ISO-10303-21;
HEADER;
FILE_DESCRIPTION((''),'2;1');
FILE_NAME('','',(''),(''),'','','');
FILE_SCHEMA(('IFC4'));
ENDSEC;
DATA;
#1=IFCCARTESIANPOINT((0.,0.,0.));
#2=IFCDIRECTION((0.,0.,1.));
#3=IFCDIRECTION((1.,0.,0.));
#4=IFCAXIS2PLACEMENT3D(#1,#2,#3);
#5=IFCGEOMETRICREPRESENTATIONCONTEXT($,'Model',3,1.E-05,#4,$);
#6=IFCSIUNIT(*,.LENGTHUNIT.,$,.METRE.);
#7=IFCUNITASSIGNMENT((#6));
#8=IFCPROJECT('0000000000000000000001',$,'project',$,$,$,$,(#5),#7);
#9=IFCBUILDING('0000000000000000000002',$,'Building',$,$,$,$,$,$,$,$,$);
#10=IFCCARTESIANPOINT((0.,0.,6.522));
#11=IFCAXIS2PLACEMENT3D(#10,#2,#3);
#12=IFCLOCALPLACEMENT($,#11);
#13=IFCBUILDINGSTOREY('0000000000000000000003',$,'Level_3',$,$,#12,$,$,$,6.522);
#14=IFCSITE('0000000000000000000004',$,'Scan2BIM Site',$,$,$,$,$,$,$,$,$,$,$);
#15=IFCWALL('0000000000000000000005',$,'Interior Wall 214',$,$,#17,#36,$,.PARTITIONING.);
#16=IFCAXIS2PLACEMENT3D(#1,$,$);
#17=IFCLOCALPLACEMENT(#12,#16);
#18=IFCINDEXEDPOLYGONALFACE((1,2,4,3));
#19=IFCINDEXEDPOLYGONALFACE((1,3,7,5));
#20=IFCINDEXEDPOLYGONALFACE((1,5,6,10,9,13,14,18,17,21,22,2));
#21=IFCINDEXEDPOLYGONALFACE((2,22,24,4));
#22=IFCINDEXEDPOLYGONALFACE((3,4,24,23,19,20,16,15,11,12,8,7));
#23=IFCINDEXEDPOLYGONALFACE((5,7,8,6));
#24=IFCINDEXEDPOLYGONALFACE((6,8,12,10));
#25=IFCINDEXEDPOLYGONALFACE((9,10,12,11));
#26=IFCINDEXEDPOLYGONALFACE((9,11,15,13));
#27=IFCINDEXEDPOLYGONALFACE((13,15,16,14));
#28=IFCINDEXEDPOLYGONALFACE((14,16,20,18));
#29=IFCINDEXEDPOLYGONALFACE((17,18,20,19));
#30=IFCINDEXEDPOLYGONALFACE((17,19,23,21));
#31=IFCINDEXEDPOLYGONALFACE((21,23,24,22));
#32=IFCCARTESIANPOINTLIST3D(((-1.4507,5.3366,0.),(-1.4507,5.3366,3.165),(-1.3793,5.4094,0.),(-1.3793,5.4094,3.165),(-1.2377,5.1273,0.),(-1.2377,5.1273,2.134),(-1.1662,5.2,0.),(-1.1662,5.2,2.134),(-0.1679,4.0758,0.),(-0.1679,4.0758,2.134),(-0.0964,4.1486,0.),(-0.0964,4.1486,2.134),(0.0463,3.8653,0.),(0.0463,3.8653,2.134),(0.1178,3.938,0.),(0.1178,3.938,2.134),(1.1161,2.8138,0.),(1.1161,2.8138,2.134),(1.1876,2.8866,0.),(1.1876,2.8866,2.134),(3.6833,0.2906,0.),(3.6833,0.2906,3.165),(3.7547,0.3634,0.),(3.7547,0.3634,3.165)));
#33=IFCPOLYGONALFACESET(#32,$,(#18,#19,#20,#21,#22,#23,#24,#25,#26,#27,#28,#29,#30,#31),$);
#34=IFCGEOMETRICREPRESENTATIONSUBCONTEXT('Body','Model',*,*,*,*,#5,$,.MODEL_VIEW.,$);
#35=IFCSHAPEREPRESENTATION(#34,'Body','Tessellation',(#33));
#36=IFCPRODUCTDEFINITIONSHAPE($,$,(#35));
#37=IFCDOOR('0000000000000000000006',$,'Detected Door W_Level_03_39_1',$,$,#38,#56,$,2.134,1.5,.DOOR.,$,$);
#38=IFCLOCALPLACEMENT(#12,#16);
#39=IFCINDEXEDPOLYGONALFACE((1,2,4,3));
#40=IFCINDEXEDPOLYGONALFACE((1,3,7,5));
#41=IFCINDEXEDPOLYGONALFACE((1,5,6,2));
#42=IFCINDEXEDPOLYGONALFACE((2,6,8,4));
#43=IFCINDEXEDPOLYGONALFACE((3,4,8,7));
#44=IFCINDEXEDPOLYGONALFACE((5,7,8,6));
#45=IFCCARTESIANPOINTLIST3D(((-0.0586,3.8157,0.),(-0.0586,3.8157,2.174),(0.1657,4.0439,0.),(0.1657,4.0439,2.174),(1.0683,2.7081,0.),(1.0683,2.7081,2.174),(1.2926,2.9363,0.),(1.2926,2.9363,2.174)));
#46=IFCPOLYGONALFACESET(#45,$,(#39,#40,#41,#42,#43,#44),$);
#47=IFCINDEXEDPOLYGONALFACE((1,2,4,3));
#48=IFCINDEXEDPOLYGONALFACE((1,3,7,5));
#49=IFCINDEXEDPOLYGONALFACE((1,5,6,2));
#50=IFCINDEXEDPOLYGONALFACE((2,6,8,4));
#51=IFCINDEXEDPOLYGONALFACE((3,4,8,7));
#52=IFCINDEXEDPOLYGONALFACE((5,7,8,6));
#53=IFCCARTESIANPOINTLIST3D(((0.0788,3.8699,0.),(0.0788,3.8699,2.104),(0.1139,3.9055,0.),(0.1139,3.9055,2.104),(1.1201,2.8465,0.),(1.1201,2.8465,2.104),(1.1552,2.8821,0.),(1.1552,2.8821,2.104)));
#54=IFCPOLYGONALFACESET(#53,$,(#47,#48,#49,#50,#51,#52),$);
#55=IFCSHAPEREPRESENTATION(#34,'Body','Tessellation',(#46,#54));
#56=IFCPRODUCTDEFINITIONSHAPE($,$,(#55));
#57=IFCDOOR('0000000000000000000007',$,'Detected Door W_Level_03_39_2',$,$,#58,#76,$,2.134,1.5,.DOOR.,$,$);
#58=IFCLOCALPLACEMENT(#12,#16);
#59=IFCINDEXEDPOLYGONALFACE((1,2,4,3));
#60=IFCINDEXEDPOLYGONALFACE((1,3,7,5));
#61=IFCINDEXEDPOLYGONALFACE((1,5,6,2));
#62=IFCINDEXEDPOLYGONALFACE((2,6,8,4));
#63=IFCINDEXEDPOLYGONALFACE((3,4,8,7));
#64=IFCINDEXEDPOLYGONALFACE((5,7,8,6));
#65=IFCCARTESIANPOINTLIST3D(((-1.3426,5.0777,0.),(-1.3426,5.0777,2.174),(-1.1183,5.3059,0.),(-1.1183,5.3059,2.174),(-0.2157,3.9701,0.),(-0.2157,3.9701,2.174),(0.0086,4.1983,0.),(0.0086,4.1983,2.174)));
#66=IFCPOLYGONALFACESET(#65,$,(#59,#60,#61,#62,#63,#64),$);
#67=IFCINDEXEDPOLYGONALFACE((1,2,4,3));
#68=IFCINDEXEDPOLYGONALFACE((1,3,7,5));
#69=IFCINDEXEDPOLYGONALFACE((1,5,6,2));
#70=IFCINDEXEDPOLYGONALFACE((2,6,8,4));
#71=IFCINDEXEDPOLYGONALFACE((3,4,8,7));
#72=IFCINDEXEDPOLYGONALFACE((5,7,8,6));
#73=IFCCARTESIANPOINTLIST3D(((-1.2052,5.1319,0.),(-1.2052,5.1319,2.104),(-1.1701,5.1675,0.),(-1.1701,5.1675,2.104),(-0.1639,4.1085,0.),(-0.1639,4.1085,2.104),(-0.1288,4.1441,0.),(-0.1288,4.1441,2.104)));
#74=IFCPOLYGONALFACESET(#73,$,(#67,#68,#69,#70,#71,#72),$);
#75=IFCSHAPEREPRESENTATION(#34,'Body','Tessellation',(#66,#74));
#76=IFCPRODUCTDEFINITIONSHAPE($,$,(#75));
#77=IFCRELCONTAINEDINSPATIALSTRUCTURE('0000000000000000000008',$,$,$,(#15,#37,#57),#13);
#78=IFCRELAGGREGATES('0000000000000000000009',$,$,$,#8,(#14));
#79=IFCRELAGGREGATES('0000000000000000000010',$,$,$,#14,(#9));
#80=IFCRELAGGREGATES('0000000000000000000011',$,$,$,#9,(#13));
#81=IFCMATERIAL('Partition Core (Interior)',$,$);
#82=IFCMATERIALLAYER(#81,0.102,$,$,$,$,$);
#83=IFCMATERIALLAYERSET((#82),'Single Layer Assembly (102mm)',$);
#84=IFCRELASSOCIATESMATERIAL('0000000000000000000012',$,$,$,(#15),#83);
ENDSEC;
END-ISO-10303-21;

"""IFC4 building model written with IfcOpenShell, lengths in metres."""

from ifc_helpers import new_model, si_unit, frame, origin, origin_with_axes, place, context, subcontext, project, spatial, rectangle, extrude, material, layer, layer_set, element, fill, save


model = new_model("IFC4")

# Units and contexts
model_context = context("Model", 3, precision=1e-05, world=origin_with_axes())
body_context = subcontext(model_context, "Body", "Model", "MODEL_VIEW")
ifc_project = project(units=[si_unit("LENGTHUNIT", "METRE")], contexts=[model_context])

# Site, building, storey
site = spatial("IfcSite", under=ifc_project, Name="Scan2BIM Site")
building = spatial("IfcBuilding", under=site, Name="Building")
storey_placement = place(None, frame((0.0, 0.0, 6.522), z_axis=(0.0, 0.0, 1.0), x_axis=(1.0, 0.0, 0.0)))
storey = spatial("IfcBuildingStorey", under=building, at=storey_placement, Name="Level_3", Elevation=6.522)

# Wall, openings, doors
ifc_material_1 = material(Name="Partition Core (Interior)")
ifc_layer_1 = layer(ifc_material_1, 0.102)
ifc_layer_set_1 = layer_set([ifc_layer_1], Name="Single Layer Assembly (102mm)")
wall_1_placement = place(storey_placement, frame((1.152, 2.85, 0.0), z_axis=(0.0, 0.0, 1.0), x_axis=(-0.713193, 0.700968, 0.0)))
wall_1 = element("IfcWall", 1, at=wall_1_placement, inside=storey, material=ifc_layer_set_1, Name="Interior Wall 214", PredefinedType="PARTITIONING", context=body_context, shape_type="SweptSolid", body=[
    extrude(rectangle(XDim=7.1986, YDim=0.102), origin(), (0.0, 0.0, 1.0), 3.165),
])
opening_1_placement = place(None, frame((0.617, 3.376, 6.522), z_axis=(0.0, 0.0, 1.0), x_axis=(-0.713193, 0.700968, 0.0)))
opening_1 = element("IfcOpeningElement", 2, at=opening_1_placement, cuts=wall_1, PredefinedType="OPENING", context=body_context, shape_type="SweptSolid", body=[
    extrude(rectangle(XDim=1.5, YDim=0.202), origin(), (0.0, 0.0, 1.0), 2.134),
])
opening_2_placement = place(None, frame((-0.667, 4.638, 6.522), z_axis=(0.0, 0.0, 1.0), x_axis=(-0.713193, 0.700968, 0.0)))
opening_2 = element("IfcOpeningElement", 3, at=opening_2_placement, cuts=wall_1, PredefinedType="OPENING", context=body_context, shape_type="SweptSolid", body=[
    extrude(rectangle(XDim=1.5, YDim=0.202), origin(), (0.0, 0.0, 1.0), 2.134),
])
door_1_placement = place(opening_1_placement, frame((0.0, 0.0, 0.0), z_axis=(0.0, 0.0, 1.0), x_axis=(1.0, 0.0, 0.0)))
door_1 = element("IfcDoor", 4, at=door_1_placement, inside=storey, Name="Detected Door W_Level_03_39_1", OverallHeight=2.134, OverallWidth=1.5, PredefinedType="DOOR", context=body_context, shape_type="SweptSolid", body=[
    extrude(rectangle(XDim=1.58, YDim=0.32), origin(), (0.0, 0.0, 1.0), 2.174),
    extrude(rectangle(XDim=1.46, YDim=0.05), origin(), (0.0, 0.0, 1.0), 2.104),
])
fill(opening_1, door_1)
door_2_placement = place(opening_2_placement, frame((0.0, 0.0, 0.0), z_axis=(0.0, 0.0, 1.0), x_axis=(1.0, 0.0, 0.0)))
door_2 = element("IfcDoor", 5, at=door_2_placement, inside=storey, Name="Detected Door W_Level_03_39_2", OverallHeight=2.134, OverallWidth=1.5, PredefinedType="DOOR", context=body_context, shape_type="SweptSolid", body=[
    extrude(rectangle(XDim=1.58, YDim=0.32), origin(), (0.0, 0.0, 1.0), 2.174),
    extrude(rectangle(XDim=1.46, YDim=0.05), origin(), (0.0, 0.0, 1.0), 2.104),
])
fill(opening_2, door_2)

save(model, "model.ifc")
